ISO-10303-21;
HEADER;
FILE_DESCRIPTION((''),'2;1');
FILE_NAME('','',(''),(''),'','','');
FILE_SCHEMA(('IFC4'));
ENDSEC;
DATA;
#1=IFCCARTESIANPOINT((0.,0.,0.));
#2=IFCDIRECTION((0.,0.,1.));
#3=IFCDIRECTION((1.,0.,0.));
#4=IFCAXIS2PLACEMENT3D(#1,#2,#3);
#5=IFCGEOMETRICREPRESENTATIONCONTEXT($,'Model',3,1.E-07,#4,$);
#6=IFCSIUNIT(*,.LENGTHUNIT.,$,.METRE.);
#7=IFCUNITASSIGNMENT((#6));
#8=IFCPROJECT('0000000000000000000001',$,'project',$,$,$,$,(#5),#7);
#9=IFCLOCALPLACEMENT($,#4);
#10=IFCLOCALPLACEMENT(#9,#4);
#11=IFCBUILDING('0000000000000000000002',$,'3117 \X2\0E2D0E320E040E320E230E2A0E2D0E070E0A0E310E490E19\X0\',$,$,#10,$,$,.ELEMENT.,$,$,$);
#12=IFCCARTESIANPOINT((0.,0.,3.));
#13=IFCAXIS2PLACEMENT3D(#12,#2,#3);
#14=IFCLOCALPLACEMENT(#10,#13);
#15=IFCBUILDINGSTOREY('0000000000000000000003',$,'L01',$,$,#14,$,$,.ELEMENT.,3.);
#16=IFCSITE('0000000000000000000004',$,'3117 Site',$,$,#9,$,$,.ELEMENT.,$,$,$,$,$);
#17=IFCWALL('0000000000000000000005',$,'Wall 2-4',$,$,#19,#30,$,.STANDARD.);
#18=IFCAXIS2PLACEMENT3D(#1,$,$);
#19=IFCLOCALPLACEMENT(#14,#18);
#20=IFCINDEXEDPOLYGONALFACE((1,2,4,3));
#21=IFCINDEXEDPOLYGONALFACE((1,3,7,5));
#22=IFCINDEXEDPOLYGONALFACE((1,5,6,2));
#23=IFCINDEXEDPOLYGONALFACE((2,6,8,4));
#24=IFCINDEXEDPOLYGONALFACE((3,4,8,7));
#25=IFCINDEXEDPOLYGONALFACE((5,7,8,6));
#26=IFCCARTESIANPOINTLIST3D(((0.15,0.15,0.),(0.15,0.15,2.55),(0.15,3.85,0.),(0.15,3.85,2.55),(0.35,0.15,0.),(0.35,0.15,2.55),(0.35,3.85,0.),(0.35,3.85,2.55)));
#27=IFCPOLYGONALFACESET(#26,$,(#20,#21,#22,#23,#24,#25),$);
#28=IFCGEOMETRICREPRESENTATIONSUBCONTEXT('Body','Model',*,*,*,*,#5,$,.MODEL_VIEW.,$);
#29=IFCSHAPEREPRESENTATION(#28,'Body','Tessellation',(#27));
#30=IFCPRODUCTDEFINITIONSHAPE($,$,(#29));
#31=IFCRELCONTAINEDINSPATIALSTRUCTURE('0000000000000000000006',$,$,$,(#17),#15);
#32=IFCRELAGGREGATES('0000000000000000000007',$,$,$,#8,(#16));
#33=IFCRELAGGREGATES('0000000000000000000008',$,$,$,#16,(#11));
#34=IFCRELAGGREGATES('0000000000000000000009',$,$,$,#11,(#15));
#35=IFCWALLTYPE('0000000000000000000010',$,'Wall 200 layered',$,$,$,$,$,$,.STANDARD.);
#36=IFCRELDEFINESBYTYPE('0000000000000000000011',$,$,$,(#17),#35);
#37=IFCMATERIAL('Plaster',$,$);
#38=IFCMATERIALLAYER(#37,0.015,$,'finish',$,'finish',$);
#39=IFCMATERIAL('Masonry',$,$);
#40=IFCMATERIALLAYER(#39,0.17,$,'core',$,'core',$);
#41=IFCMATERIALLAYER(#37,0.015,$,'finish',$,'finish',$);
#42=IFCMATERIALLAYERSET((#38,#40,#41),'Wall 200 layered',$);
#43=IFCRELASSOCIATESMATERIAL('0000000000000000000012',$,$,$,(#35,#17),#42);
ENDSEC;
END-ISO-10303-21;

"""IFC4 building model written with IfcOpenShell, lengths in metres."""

from ifc_helpers import new_model, si_unit, frame, origin_with_axes, place, context, subcontext, project, spatial, polyline, outline, extrude, material, layer, layer_set, layer_usage, type_object, element, save


model = new_model("IFC4")

# Units and contexts
model_context = context("Model", 3, precision=1e-07, world=origin_with_axes())
body_context = subcontext(model_context, "Body", "Model", "MODEL_VIEW")
ifc_project = project(units=[si_unit("LENGTHUNIT", "METRE")], contexts=[model_context])

# Site, building, storey
site_placement = place(None, origin_with_axes())
site = spatial("IfcSite", under=ifc_project, at=site_placement, Name="3117 Site", CompositionType="ELEMENT")
building_placement = place(site_placement, origin_with_axes())
building = spatial("IfcBuilding", under=site, at=building_placement, Name="3117 อาคารสองชั้น", CompositionType="ELEMENT")
storey_placement = place(building_placement, frame((0.0, 0.0, 3.0), z_axis=(0.0, 0.0, 1.0), x_axis=(1.0, 0.0, 0.0)))
storey = spatial("IfcBuildingStorey", under=building, at=storey_placement, Name="L01", CompositionType="ELEMENT", Elevation=3.0)

# Shared definitions
ifc_material_1 = material(Name="Plaster")
ifc_layer_1 = layer(ifc_material_1, 0.015, Name="finish", Category="finish")
ifc_material_2 = material(Name="Masonry")
ifc_layer_2 = layer(ifc_material_2, 0.17, Name="core", Category="core")
ifc_layer_3 = layer(ifc_material_1, 0.015, Name="finish", Category="finish")
ifc_layer_set_1 = layer_set([ifc_layer_1, ifc_layer_2, ifc_layer_3], Name="Wall 200 layered")
wall_type = type_object("IfcWallType", Name="Wall 200 layered", PredefinedType="STANDARD", material=ifc_layer_set_1)

# Wall
ifc_layer_usage_1 = layer_usage(ifc_layer_set_1, "AXIS2", "POSITIVE", 0.0)
wall_1_placement = place(storey_placement, frame((0.15, 3.85, 0.0), z_axis=(0.0, 0.0, 1.0), x_axis=(0.0, -1.0, 0.0)))
element("IfcWall", 1, at=wall_1_placement, inside=storey, type_object=wall_type, material=ifc_layer_usage_1, Name="Wall 2-4", PredefinedType="STANDARD", context=body_context, shape_type="SweptSolid", body=[
    extrude(outline(polyline([(0.0, 0.0), (3.7, 0.0), (3.7, 0.2), (0.0, 0.2), (0.0, 0.0)])), origin_with_axes(), (0.0, 0.0, 1.0), 2.55),
])

save(model, "model.ifc")
